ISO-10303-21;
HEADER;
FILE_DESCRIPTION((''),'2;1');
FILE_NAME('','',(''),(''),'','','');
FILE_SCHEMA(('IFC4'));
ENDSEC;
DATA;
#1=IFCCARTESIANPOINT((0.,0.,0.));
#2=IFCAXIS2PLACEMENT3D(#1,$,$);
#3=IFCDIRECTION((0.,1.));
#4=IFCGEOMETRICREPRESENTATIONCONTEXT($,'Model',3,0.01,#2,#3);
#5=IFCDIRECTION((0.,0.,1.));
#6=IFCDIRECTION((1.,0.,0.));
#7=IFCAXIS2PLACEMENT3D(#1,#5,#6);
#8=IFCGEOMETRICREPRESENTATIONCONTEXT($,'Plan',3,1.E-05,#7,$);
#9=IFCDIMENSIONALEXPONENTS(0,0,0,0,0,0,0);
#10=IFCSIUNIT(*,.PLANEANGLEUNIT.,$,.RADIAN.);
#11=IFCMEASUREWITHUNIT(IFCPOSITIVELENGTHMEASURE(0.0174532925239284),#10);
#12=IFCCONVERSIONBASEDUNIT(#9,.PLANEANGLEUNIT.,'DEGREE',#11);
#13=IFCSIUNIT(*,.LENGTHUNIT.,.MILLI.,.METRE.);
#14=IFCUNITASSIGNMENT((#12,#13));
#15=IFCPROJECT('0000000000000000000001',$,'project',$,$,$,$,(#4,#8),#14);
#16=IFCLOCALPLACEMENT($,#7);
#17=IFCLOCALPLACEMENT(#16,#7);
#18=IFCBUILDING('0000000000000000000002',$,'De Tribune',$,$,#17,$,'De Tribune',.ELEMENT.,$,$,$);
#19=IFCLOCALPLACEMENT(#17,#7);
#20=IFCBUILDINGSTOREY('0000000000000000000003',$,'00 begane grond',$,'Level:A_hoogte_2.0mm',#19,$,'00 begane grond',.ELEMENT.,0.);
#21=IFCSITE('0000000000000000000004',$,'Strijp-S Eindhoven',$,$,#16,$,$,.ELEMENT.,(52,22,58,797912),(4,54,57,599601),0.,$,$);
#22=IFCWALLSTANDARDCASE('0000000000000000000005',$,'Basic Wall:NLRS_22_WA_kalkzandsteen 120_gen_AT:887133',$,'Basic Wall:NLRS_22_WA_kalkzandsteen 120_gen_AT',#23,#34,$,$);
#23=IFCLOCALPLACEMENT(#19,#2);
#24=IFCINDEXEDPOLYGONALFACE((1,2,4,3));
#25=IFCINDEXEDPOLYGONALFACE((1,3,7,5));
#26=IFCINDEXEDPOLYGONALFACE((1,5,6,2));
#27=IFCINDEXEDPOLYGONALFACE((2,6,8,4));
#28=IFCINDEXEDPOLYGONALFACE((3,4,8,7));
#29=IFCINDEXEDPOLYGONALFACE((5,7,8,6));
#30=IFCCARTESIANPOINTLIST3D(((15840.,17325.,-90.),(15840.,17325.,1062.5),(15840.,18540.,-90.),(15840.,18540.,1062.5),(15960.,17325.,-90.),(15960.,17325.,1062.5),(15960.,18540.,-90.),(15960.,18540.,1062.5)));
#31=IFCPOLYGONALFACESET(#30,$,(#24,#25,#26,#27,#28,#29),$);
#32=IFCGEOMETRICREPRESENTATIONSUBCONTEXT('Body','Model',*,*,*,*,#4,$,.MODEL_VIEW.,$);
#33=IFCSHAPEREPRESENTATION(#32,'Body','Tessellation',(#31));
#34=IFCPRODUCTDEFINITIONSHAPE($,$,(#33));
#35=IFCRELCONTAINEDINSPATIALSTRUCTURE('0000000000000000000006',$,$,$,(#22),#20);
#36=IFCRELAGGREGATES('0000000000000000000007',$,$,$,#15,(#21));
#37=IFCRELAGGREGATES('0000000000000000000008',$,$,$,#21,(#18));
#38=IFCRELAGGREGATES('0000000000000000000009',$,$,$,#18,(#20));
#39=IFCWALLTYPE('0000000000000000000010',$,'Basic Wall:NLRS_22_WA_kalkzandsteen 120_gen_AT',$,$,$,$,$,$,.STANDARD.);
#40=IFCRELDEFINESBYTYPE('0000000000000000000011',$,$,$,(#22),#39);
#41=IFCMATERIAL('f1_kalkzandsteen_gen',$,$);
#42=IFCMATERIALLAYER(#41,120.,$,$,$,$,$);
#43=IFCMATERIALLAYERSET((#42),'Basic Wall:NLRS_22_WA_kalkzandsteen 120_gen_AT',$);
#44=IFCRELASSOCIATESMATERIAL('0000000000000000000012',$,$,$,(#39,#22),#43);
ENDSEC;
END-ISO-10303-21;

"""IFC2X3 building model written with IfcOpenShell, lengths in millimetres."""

from ifc_helpers import new_model, entity, si_unit, converted_unit, direction, frame, frame_2d, origin, origin_with_axes, place, context, subcontext, project, spatial, rectangle, extrude, material, layer, layer_set, layer_usage, type_object, element, save


model = new_model("IFC2X3")

# Units and contexts
model_context = context("Model", 3, precision=0.01, world=origin(), true_north=direction((0.0, 1.0)))
plan_context = context("Plan", 3, precision=1e-05, world=origin_with_axes())
body_context = subcontext(model_context, "Body", "Model", "MODEL_VIEW")
ifc_project = project(units=[converted_unit("PLANEANGLEUNIT", "DEGREE", entity("IfcPositiveLengthMeasure", 0.0174532925239284), si_unit("PLANEANGLEUNIT", "RADIAN"), dimensions=[0, 0, 0, 0, 0, 0, 0]), si_unit("LENGTHUNIT", "METRE", prefix="MILLI")], contexts=[model_context, plan_context])

# Site, building, storey
site_placement = place(None, origin_with_axes())
site = spatial("IfcSite", under=ifc_project, at=site_placement, Name="Strijp-S Eindhoven", CompositionType="ELEMENT", RefLatitude=(52, 22, 58, 797912), RefLongitude=(4, 54, 57, 599601), RefElevation=0.0)
building_placement = place(site_placement, origin_with_axes())
building = spatial("IfcBuilding", under=site, at=building_placement, Name="De Tribune", LongName="De Tribune", CompositionType="ELEMENT")
storey_placement = place(building_placement, origin_with_axes())
storey = spatial("IfcBuildingStorey", under=building, at=storey_placement, Name="00 begane grond", ObjectType="Level:A_hoogte_2.0mm", LongName="00 begane grond", CompositionType="ELEMENT", Elevation=0.0)

# Wall
ifc_material_1 = material(Name="f1_kalkzandsteen_gen")
ifc_layer_1 = layer(ifc_material_1, 120.0)
ifc_layer_set_1 = layer_set([ifc_layer_1], Name="Basic Wall:NLRS_22_WA_kalkzandsteen 120_gen_AT")
ifc_layer_usage_1 = layer_usage(ifc_layer_set_1, "AXIS2", "POSITIVE", -60.0)
wall_type_1 = type_object("IfcWallType", Name="Basic Wall:NLRS_22_WA_kalkzandsteen 120_gen_AT", PredefinedType="STANDARD", material=ifc_layer_set_1)
wall_1_placement = place(storey_placement, frame((15900.0, 18540.0, -90.0), z_axis=(0.0, 0.0, 1.0), x_axis=(0.0, -1.0, 0.0)))
element("IfcWallStandardCase", 1, at=wall_1_placement, inside=storey, type_object=wall_type_1, material=ifc_layer_usage_1, Name="Basic Wall:NLRS_22_WA_kalkzandsteen 120_gen_AT:887133", ObjectType="Basic Wall:NLRS_22_WA_kalkzandsteen 120_gen_AT", context=body_context, shape_type="SweptSolid", body=[
    extrude(rectangle(XDim=1215.0, YDim=120.0, at=frame_2d((607.5, 0.0), x_axis=(-1.0, 0.0))), origin(), (0.0, 0.0, 1.0), 1152.5),
])

save(model, "model.ifc")
